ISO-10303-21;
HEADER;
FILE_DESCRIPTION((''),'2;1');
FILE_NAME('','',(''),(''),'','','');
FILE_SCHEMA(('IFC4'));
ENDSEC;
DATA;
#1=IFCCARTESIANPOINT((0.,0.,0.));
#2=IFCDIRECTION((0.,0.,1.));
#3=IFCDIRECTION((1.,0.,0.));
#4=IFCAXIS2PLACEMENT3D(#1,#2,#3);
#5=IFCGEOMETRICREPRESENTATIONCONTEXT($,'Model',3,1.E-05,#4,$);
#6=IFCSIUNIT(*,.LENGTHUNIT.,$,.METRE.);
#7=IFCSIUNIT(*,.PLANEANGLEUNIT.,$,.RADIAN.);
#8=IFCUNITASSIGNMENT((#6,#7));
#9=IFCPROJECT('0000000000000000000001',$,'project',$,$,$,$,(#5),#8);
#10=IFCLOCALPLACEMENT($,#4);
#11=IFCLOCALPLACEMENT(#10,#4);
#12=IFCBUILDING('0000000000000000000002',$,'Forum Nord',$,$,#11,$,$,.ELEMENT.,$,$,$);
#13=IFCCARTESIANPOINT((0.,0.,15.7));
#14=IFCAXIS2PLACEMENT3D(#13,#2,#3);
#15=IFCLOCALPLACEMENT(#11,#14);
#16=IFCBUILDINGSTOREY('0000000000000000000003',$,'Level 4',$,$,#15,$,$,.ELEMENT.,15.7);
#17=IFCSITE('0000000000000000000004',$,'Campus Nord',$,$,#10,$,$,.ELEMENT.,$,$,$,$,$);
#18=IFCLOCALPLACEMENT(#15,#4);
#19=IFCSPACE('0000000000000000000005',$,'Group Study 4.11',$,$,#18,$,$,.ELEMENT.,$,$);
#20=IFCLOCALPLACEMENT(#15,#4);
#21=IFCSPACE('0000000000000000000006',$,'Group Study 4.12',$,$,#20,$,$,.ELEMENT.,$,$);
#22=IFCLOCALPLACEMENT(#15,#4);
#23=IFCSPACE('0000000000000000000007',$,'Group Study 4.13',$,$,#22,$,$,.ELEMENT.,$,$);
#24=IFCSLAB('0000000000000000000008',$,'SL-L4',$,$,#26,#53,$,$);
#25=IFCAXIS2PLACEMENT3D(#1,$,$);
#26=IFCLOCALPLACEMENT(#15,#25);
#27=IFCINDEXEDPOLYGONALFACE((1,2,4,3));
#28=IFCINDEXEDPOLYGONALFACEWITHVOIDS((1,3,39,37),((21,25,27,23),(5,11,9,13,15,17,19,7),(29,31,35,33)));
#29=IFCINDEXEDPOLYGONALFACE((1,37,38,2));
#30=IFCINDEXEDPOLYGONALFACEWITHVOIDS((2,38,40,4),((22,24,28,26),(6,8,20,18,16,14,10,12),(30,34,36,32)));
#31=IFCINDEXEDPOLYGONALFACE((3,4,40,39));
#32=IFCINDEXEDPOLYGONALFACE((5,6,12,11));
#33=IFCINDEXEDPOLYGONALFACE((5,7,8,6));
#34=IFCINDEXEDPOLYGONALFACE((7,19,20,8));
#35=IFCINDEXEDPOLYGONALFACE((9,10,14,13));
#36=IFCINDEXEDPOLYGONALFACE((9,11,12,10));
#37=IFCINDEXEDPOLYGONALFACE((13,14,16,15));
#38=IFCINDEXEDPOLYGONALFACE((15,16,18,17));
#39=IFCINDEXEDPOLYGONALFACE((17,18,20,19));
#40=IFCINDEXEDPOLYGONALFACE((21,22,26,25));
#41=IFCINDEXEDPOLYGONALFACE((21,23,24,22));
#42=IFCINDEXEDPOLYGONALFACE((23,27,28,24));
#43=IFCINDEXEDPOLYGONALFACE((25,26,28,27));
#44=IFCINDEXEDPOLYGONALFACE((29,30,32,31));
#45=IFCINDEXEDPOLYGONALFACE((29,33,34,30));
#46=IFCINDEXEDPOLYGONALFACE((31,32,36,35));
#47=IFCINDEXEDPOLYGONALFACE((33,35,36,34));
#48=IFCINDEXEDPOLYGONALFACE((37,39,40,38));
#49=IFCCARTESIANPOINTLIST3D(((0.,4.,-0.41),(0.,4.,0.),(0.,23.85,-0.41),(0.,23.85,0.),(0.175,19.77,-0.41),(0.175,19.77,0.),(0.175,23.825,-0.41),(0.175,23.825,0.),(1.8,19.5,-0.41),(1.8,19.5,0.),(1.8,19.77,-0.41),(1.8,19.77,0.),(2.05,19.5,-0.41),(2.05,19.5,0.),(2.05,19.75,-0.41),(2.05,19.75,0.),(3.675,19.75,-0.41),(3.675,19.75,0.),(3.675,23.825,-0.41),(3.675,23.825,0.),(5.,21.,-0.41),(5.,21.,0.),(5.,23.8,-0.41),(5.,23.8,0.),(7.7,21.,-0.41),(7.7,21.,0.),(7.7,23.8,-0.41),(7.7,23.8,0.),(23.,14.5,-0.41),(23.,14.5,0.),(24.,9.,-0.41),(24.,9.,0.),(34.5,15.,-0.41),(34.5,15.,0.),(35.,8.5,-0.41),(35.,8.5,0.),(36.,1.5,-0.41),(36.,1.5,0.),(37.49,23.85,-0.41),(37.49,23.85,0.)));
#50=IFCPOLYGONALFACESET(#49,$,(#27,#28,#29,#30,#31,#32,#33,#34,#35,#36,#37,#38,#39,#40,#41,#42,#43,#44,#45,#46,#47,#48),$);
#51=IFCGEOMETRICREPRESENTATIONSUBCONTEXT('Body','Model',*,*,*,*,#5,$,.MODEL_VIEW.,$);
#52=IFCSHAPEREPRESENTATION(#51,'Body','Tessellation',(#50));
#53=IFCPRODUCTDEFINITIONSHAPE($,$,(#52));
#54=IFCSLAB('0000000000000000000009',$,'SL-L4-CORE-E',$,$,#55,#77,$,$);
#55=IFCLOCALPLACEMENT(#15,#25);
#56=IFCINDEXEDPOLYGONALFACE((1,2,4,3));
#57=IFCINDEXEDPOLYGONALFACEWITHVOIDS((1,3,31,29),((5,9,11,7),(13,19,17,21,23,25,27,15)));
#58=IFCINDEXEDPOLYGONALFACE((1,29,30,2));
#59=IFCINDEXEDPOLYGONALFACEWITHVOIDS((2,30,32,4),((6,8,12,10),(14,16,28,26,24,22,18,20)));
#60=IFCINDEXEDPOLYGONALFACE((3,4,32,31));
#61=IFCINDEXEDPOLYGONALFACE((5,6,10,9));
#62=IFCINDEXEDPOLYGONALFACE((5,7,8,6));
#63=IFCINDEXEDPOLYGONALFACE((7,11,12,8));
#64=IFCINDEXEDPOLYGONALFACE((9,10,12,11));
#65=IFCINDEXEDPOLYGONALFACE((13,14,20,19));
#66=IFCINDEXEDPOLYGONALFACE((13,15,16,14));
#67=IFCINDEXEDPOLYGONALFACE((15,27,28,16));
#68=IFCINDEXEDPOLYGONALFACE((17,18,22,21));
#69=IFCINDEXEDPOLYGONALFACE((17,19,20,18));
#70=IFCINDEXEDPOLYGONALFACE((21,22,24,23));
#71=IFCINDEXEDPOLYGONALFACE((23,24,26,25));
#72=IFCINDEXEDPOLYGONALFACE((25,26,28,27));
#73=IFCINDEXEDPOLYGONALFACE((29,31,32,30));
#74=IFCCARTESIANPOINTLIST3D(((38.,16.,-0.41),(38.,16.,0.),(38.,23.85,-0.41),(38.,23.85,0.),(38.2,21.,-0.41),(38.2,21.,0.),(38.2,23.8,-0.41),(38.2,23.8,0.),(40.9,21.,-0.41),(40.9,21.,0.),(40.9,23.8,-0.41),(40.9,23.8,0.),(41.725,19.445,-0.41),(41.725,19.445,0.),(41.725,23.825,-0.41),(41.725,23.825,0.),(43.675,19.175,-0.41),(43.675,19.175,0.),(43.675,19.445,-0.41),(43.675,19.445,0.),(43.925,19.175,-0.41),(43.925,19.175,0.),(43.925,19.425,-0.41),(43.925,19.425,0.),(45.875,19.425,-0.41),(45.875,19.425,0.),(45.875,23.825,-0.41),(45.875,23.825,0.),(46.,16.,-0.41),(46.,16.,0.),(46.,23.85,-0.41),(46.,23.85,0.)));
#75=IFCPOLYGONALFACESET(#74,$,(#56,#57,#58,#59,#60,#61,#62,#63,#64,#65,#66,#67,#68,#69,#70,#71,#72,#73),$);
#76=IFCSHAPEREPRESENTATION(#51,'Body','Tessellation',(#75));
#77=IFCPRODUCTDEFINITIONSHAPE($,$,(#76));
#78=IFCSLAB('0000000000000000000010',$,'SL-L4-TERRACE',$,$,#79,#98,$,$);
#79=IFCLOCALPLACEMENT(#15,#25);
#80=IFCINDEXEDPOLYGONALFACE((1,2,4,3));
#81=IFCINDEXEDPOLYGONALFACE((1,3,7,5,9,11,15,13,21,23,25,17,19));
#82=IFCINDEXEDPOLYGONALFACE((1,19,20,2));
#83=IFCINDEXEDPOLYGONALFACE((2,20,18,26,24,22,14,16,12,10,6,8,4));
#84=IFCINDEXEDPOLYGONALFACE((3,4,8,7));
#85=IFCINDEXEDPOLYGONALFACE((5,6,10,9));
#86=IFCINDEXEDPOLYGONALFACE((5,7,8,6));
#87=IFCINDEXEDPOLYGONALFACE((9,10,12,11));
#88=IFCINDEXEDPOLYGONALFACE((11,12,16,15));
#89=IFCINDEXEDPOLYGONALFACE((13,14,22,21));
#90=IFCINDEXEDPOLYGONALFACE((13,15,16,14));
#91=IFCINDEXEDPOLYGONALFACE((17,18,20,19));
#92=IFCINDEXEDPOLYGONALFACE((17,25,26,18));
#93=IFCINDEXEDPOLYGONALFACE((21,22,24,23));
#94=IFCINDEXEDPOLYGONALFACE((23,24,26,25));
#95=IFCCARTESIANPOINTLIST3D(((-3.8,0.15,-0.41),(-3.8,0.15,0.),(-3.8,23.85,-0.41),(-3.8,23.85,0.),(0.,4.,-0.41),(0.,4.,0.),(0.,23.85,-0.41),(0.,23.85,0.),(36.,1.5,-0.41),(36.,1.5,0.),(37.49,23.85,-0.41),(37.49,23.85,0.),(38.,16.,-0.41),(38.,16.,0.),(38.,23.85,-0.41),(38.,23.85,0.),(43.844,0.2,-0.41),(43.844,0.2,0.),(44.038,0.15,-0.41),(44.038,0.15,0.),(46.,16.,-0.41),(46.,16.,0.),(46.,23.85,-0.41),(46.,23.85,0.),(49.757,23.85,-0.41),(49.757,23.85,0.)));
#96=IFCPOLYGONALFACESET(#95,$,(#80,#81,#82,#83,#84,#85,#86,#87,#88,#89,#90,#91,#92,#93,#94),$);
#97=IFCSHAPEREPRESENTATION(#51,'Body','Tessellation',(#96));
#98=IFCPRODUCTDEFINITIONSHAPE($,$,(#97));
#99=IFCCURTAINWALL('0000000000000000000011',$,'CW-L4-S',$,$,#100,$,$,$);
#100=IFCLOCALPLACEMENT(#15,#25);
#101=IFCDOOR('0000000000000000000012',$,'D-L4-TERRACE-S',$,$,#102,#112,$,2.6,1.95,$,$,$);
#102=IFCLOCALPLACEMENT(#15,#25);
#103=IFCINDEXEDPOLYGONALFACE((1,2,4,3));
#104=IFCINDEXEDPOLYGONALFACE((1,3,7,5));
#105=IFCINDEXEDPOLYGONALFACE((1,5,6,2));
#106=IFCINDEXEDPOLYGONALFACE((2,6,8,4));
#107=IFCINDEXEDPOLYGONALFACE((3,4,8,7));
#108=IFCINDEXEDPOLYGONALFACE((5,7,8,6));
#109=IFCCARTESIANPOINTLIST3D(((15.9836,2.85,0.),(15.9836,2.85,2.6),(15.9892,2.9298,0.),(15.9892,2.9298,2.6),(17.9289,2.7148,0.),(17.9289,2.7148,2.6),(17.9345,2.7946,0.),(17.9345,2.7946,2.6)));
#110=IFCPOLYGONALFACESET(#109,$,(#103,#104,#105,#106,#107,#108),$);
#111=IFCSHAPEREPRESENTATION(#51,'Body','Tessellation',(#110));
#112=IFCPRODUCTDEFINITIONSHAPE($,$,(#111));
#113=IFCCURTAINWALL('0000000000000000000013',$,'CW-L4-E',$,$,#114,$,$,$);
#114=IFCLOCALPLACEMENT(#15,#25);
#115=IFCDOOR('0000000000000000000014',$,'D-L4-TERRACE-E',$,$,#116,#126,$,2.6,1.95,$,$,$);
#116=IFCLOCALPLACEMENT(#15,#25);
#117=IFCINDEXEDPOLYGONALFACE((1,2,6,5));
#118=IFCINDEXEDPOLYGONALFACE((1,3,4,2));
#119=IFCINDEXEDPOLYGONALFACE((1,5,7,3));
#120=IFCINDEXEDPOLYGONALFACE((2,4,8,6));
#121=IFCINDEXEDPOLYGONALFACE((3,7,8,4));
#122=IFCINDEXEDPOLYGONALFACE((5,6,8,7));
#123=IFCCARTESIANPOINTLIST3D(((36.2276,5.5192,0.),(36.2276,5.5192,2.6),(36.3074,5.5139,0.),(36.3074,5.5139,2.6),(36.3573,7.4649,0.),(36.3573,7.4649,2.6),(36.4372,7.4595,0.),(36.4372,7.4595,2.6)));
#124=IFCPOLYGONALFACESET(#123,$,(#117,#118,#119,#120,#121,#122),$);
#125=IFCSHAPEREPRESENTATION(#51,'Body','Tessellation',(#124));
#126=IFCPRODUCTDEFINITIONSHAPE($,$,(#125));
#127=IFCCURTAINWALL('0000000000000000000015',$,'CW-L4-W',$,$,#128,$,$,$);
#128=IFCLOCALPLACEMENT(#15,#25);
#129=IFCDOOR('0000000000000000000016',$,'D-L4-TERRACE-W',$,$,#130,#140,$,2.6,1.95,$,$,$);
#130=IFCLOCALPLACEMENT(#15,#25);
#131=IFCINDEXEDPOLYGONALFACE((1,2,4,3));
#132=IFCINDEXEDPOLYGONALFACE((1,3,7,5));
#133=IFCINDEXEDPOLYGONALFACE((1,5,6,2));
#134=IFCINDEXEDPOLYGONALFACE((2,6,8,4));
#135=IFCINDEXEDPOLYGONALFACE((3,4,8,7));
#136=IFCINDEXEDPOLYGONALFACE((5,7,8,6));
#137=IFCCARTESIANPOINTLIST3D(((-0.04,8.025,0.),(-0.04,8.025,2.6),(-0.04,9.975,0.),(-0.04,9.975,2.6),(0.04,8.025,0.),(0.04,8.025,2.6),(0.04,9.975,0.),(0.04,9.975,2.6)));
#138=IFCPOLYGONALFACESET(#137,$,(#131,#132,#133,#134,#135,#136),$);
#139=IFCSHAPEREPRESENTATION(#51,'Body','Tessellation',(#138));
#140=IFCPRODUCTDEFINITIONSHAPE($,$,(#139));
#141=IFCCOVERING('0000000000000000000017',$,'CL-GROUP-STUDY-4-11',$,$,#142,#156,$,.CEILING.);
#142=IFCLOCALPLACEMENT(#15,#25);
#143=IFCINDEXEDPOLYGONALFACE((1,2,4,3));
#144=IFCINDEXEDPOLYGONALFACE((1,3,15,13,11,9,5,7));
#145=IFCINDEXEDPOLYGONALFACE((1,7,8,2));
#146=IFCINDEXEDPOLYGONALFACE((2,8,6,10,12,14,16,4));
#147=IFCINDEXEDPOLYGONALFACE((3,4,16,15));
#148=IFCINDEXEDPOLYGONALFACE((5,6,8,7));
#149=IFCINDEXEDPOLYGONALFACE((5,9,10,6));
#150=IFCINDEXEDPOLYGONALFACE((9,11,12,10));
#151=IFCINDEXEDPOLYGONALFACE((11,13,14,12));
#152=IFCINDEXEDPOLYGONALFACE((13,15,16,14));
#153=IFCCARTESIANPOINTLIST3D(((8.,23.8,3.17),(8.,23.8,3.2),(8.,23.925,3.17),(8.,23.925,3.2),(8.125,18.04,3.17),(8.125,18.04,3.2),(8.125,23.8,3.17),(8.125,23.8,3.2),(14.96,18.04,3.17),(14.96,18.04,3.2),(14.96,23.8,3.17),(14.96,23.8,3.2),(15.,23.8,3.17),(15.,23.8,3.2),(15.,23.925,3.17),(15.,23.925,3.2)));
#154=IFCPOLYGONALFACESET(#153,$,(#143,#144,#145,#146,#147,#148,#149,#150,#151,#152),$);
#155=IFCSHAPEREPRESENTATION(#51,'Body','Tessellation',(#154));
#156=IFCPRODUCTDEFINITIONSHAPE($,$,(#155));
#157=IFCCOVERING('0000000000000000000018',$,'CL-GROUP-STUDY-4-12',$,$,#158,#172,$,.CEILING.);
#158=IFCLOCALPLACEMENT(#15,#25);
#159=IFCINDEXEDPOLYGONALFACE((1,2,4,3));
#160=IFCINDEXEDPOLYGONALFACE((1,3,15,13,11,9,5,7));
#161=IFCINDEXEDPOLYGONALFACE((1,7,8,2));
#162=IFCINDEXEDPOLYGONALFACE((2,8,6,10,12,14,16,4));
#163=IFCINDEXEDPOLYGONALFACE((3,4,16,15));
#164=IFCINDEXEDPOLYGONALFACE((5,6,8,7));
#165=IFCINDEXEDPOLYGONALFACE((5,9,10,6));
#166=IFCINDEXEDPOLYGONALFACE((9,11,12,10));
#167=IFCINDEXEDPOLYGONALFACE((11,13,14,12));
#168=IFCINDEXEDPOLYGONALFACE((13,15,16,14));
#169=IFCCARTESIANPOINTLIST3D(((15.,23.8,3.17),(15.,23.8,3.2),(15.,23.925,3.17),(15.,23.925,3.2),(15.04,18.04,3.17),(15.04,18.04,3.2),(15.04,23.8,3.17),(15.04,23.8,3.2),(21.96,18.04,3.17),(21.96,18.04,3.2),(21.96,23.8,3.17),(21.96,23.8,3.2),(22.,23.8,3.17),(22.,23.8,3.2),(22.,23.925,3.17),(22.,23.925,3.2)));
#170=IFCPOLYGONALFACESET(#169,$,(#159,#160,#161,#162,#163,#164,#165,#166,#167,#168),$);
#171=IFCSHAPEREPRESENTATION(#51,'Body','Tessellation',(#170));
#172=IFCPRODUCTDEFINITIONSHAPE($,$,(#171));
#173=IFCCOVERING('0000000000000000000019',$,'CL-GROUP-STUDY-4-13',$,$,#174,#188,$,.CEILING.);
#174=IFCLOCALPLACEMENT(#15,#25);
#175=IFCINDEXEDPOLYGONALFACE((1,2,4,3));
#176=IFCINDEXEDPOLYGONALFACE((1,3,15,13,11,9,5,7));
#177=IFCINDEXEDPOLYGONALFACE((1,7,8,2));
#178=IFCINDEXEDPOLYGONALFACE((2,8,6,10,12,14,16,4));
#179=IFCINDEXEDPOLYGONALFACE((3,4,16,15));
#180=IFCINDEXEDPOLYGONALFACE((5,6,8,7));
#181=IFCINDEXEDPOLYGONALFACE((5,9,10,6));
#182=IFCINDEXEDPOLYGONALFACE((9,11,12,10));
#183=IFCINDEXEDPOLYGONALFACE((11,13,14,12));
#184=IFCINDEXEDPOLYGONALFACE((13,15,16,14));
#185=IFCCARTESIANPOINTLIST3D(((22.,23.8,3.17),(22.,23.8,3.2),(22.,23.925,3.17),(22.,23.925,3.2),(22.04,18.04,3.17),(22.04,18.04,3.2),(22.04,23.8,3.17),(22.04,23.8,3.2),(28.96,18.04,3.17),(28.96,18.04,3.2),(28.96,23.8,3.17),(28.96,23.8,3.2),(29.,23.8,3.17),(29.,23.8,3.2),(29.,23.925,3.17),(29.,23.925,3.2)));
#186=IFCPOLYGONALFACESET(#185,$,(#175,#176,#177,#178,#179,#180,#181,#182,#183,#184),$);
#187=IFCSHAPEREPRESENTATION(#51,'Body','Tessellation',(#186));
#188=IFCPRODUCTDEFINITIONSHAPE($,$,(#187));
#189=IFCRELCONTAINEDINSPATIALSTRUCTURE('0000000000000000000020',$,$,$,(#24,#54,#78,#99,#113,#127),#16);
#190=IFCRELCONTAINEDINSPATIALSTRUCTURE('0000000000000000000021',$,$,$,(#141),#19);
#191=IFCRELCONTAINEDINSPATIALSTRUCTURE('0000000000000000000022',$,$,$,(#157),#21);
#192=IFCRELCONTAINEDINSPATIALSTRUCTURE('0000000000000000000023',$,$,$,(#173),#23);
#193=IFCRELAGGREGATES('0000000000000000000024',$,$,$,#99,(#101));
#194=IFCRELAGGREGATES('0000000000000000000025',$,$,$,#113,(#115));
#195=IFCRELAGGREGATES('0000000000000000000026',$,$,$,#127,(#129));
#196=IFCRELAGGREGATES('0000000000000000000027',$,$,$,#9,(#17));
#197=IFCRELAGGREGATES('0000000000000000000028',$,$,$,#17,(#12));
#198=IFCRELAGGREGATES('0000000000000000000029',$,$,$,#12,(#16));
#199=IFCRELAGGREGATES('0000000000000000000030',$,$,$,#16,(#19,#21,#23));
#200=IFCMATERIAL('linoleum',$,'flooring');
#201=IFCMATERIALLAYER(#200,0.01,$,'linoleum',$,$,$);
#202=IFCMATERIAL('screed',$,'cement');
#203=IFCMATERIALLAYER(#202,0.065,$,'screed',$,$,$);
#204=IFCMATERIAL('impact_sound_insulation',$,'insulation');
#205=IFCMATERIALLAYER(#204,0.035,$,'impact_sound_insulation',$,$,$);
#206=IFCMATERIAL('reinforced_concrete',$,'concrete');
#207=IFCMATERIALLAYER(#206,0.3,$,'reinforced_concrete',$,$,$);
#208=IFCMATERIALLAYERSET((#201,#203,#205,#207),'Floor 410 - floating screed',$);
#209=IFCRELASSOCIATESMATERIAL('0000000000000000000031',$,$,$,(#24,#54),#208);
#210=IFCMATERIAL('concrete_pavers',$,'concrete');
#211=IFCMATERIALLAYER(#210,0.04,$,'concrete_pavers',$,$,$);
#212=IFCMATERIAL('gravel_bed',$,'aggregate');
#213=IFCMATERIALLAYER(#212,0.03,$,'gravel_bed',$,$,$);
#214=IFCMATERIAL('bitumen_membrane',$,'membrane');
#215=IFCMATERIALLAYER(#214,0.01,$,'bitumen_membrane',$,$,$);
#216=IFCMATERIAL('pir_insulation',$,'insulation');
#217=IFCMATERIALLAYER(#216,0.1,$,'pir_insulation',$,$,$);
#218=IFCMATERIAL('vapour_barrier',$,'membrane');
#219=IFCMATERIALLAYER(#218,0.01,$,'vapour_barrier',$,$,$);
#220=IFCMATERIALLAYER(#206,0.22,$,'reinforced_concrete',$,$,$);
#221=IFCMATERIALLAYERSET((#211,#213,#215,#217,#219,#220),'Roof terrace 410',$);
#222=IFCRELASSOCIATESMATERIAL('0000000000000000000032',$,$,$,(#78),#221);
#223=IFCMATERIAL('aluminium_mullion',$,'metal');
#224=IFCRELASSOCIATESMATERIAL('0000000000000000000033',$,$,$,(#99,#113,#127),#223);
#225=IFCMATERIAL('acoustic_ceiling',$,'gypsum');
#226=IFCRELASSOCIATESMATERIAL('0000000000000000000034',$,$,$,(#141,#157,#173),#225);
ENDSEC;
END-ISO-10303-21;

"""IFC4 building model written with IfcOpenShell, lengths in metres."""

from ifc_helpers import new_model, si_unit, frame, origin_with_axes, place, context, subcontext, project, spatial, polyline, outline, extrude, material, layer, layer_set, layer_usage, element, aggregate, save


model = new_model("IFC4")

# Units and contexts
model_context = context("Model", 3, precision=1e-05, world=origin_with_axes())
body_context = subcontext(model_context, "Body", "Model", "MODEL_VIEW")
ifc_project = project(units=[si_unit("LENGTHUNIT", "METRE"), si_unit("PLANEANGLEUNIT", "RADIAN")], contexts=[model_context])

# Site, building, storey
site_placement = place(None, origin_with_axes())
site = spatial("IfcSite", under=ifc_project, at=site_placement, Name="Campus Nord", CompositionType="ELEMENT")
building_placement = place(site_placement, origin_with_axes())
building = spatial("IfcBuilding", under=site, at=building_placement, Name="Forum Nord", CompositionType="ELEMENT")
storey_placement = place(building_placement, frame((0.0, 0.0, 15.7), z_axis=(0.0, 0.0, 1.0), x_axis=(1.0, 0.0, 0.0)))
storey = spatial("IfcBuildingStorey", under=building, at=storey_placement, Name="Level 4", CompositionType="ELEMENT", Elevation=15.7)

# Slabs
ifc_material_1 = material(Name="linoleum", Category="flooring")
ifc_layer_1 = layer(ifc_material_1, 0.01, Name="linoleum")
ifc_material_2 = material(Name="screed", Category="cement")
ifc_layer_2 = layer(ifc_material_2, 0.065, Name="screed")
ifc_material_3 = material(Name="impact_sound_insulation", Category="insulation")
ifc_layer_3 = layer(ifc_material_3, 0.035, Name="impact_sound_insulation")
ifc_material_4 = material(Name="reinforced_concrete", Category="concrete")
ifc_layer_4 = layer(ifc_material_4, 0.3, Name="reinforced_concrete")
ifc_layer_set_1 = layer_set([ifc_layer_1, ifc_layer_2, ifc_layer_3, ifc_layer_4], Name="Floor 410 - floating screed")
ifc_layer_usage_1 = layer_usage(ifc_layer_set_1, "AXIS3", "NEGATIVE", 0.0)
slab_1_placement = place(storey_placement, origin_with_axes())
element("IfcSlab", 1, at=slab_1_placement, inside=storey, material=ifc_layer_usage_1, Name="SL-L4", context=body_context, shape_type="SweptSolid", body=[
    extrude(outline(polyline([(36.0, 1.5), (37.49, 23.85), (0.0, 23.85), (0.0, 4.0), (36.0, 1.5)]), holes=[polyline([(23.0, 14.5), (34.5, 15.0), (35.0, 8.5), (24.0, 9.0), (23.0, 14.5)]), polyline([(5.0, 23.8), (7.7, 23.8), (7.7, 21.0), (5.0, 21.0), (5.0, 23.8)]), polyline([(3.675, 19.75), (2.05, 19.75), (2.05, 19.5), (1.8, 19.5), (1.8, 19.77), (0.175, 19.77), (0.175, 23.825), (3.675, 23.825), (3.675, 19.75)])]), frame((0.0, 0.0, -0.41), z_axis=(0.0, 0.0, 1.0), x_axis=(1.0, 0.0, 0.0)), (0.0, 0.0, 1.0), 0.41),
])
slab_2_placement = place(storey_placement, origin_with_axes())
element("IfcSlab", 2, at=slab_2_placement, inside=storey, material=ifc_layer_usage_1, Name="SL-L4-CORE-E", context=body_context, shape_type="SweptSolid", body=[
    extrude(outline(polyline([(46.0, 16.0), (46.0, 23.85), (38.0, 23.85), (38.0, 16.0), (46.0, 16.0)]), holes=[polyline([(45.875, 19.425), (43.925, 19.425), (43.925, 19.175), (43.675, 19.175), (43.675, 19.445), (41.725, 19.445), (41.725, 23.825), (45.875, 23.825), (45.875, 19.425)]), polyline([(38.2, 23.8), (40.9, 23.8), (40.9, 21.0), (38.2, 21.0), (38.2, 23.8)])]), frame((0.0, 0.0, -0.41), z_axis=(0.0, 0.0, 1.0), x_axis=(1.0, 0.0, 0.0)), (0.0, 0.0, 1.0), 0.41),
])
ifc_material_5 = material(Name="concrete_pavers", Category="concrete")
ifc_layer_5 = layer(ifc_material_5, 0.04, Name="concrete_pavers")
ifc_material_6 = material(Name="gravel_bed", Category="aggregate")
ifc_layer_6 = layer(ifc_material_6, 0.03, Name="gravel_bed")
ifc_material_7 = material(Name="bitumen_membrane", Category="membrane")
ifc_layer_7 = layer(ifc_material_7, 0.01, Name="bitumen_membrane")
ifc_material_8 = material(Name="pir_insulation", Category="insulation")
ifc_layer_8 = layer(ifc_material_8, 0.1, Name="pir_insulation")
ifc_material_9 = material(Name="vapour_barrier", Category="membrane")
ifc_layer_9 = layer(ifc_material_9, 0.01, Name="vapour_barrier")
ifc_layer_10 = layer(ifc_material_4, 0.22, Name="reinforced_concrete")
ifc_layer_set_2 = layer_set([ifc_layer_5, ifc_layer_6, ifc_layer_7, ifc_layer_8, ifc_layer_9, ifc_layer_10], Name="Roof terrace 410")
ifc_layer_usage_2 = layer_usage(ifc_layer_set_2, "AXIS3", "NEGATIVE", 0.0)
slab_3_placement = place(storey_placement, origin_with_axes())
element("IfcSlab", 3, at=slab_3_placement, inside=storey, material=ifc_layer_usage_2, Name="SL-L4-TERRACE", context=body_context, shape_type="SweptSolid", body=[
    extrude(outline(polyline([(44.038, 0.15), (43.844, 0.2), (49.757, 23.85), (46.0, 23.85), (46.0, 16.0), (38.0, 16.0), (38.0, 23.85), (37.49, 23.85), (36.0, 1.5), (0.0, 4.0), (0.0, 23.85), (-3.8, 23.85), (-3.8, 0.15), (44.038, 0.15)])), frame((0.0, 0.0, -0.41), z_axis=(0.0, 0.0, 1.0), x_axis=(1.0, 0.0, 0.0)), (0.0, 0.0, 1.0), 0.41),
])

# Curtain walls, doors
ifc_material_10 = material(Name="aluminium_mullion", Category="metal")
curtain_wall_1_placement = place(storey_placement, origin_with_axes())
curtain_wall_1 = element("IfcCurtainWall", 4, at=curtain_wall_1_placement, inside=storey, material=ifc_material_10, Name="CW-L4-S")
door_1_placement = place(storey_placement, origin_with_axes())
door_1 = element("IfcDoor", 5, at=door_1_placement, Name="D-L4-TERRACE-S", OverallHeight=2.6, OverallWidth=1.95, context=body_context, shape_type="SweptSolid", body=[
    extrude(outline(polyline([(15.9836, 2.85), (17.9289, 2.7148), (17.9345, 2.7946), (15.9892, 2.9298), (15.9836, 2.85)])), origin_with_axes(), (0.0, 0.0, 1.0), 2.6),
])
aggregate(curtain_wall_1, [door_1])
curtain_wall_2_placement = place(storey_placement, origin_with_axes())
curtain_wall_2 = element("IfcCurtainWall", 6, at=curtain_wall_2_placement, inside=storey, material=ifc_material_10, Name="CW-L4-E")
door_2_placement = place(storey_placement, origin_with_axes())
door_2 = element("IfcDoor", 7, at=door_2_placement, Name="D-L4-TERRACE-E", OverallHeight=2.6, OverallWidth=1.95, context=body_context, shape_type="SweptSolid", body=[
    extrude(outline(polyline([(36.3074, 5.5139), (36.4372, 7.4595), (36.3573, 7.4649), (36.2276, 5.5192), (36.3074, 5.5139)])), origin_with_axes(), (0.0, 0.0, 1.0), 2.6),
])
aggregate(curtain_wall_2, [door_2])
curtain_wall_3_placement = place(storey_placement, origin_with_axes())
curtain_wall_3 = element("IfcCurtainWall", 8, at=curtain_wall_3_placement, inside=storey, material=ifc_material_10, Name="CW-L4-W")
door_3_placement = place(storey_placement, origin_with_axes())
door_3 = element("IfcDoor", 9, at=door_3_placement, Name="D-L4-TERRACE-W", OverallHeight=2.6, OverallWidth=1.95, context=body_context, shape_type="SweptSolid", body=[
    extrude(outline(polyline([(-0.04, 9.975), (-0.04, 8.025), (0.04, 8.025), (0.04, 9.975), (-0.04, 9.975)])), origin_with_axes(), (0.0, 0.0, 1.0), 2.6),
])
aggregate(curtain_wall_3, [door_3])

# Shared definitions
space_1_placement = place(storey_placement, origin_with_axes())
space_1 = spatial("IfcSpace", under=storey, at=space_1_placement, Name="Group Study 4.11", CompositionType="ELEMENT")

# Covering
ifc_material_11 = material(Name="acoustic_ceiling", Category="gypsum")
covering_1_placement = place(storey_placement, frame((0.0, 0.0, 3.17), z_axis=(0.0, 0.0, 1.0), x_axis=(1.0, 0.0, 0.0)))
element("IfcCovering", 10, at=covering_1_placement, inside=space_1, material=ifc_material_11, Name="CL-GROUP-STUDY-4-11", PredefinedType="CEILING", context=body_context, shape_type="SweptSolid", body=[
    extrude(outline(polyline([(8.0, 23.8), (8.125, 23.8), (8.125, 18.04), (14.96, 18.04), (14.96, 23.8), (15.0, 23.8), (15.0, 23.925), (8.0, 23.925), (8.0, 23.8)])), origin_with_axes(), (0.0, 0.0, 1.0), 0.03),
])

# Shared definitions
space_2_placement = place(storey_placement, origin_with_axes())
space_2 = spatial("IfcSpace", under=storey, at=space_2_placement, Name="Group Study 4.12", CompositionType="ELEMENT")

# Covering
covering_2_placement = place(storey_placement, frame((0.0, 0.0, 3.17), z_axis=(0.0, 0.0, 1.0), x_axis=(1.0, 0.0, 0.0)))
element("IfcCovering", 11, at=covering_2_placement, inside=space_2, material=ifc_material_11, Name="CL-GROUP-STUDY-4-12", PredefinedType="CEILING", context=body_context, shape_type="SweptSolid", body=[
    extrude(outline(polyline([(15.0, 23.925), (15.0, 23.8), (15.04, 23.8), (15.04, 18.04), (21.96, 18.04), (21.96, 23.8), (22.0, 23.8), (22.0, 23.925), (15.0, 23.925)])), origin_with_axes(), (0.0, 0.0, 1.0), 0.03),
])

# Shared definitions
space_3_placement = place(storey_placement, origin_with_axes())
space_3 = spatial("IfcSpace", under=storey, at=space_3_placement, Name="Group Study 4.13", CompositionType="ELEMENT")

# Covering
covering_3_placement = place(storey_placement, frame((0.0, 0.0, 3.17), z_axis=(0.0, 0.0, 1.0), x_axis=(1.0, 0.0, 0.0)))
element("IfcCovering", 12, at=covering_3_placement, inside=space_3, material=ifc_material_11, Name="CL-GROUP-STUDY-4-13", PredefinedType="CEILING", context=body_context, shape_type="SweptSolid", body=[
    extrude(outline(polyline([(22.0, 23.925), (22.0, 23.8), (22.04, 23.8), (22.04, 18.04), (28.96, 18.04), (28.96, 23.8), (29.0, 23.8), (29.0, 23.925), (22.0, 23.925)])), origin_with_axes(), (0.0, 0.0, 1.0), 0.03),
])

save(model, "model.ifc")
